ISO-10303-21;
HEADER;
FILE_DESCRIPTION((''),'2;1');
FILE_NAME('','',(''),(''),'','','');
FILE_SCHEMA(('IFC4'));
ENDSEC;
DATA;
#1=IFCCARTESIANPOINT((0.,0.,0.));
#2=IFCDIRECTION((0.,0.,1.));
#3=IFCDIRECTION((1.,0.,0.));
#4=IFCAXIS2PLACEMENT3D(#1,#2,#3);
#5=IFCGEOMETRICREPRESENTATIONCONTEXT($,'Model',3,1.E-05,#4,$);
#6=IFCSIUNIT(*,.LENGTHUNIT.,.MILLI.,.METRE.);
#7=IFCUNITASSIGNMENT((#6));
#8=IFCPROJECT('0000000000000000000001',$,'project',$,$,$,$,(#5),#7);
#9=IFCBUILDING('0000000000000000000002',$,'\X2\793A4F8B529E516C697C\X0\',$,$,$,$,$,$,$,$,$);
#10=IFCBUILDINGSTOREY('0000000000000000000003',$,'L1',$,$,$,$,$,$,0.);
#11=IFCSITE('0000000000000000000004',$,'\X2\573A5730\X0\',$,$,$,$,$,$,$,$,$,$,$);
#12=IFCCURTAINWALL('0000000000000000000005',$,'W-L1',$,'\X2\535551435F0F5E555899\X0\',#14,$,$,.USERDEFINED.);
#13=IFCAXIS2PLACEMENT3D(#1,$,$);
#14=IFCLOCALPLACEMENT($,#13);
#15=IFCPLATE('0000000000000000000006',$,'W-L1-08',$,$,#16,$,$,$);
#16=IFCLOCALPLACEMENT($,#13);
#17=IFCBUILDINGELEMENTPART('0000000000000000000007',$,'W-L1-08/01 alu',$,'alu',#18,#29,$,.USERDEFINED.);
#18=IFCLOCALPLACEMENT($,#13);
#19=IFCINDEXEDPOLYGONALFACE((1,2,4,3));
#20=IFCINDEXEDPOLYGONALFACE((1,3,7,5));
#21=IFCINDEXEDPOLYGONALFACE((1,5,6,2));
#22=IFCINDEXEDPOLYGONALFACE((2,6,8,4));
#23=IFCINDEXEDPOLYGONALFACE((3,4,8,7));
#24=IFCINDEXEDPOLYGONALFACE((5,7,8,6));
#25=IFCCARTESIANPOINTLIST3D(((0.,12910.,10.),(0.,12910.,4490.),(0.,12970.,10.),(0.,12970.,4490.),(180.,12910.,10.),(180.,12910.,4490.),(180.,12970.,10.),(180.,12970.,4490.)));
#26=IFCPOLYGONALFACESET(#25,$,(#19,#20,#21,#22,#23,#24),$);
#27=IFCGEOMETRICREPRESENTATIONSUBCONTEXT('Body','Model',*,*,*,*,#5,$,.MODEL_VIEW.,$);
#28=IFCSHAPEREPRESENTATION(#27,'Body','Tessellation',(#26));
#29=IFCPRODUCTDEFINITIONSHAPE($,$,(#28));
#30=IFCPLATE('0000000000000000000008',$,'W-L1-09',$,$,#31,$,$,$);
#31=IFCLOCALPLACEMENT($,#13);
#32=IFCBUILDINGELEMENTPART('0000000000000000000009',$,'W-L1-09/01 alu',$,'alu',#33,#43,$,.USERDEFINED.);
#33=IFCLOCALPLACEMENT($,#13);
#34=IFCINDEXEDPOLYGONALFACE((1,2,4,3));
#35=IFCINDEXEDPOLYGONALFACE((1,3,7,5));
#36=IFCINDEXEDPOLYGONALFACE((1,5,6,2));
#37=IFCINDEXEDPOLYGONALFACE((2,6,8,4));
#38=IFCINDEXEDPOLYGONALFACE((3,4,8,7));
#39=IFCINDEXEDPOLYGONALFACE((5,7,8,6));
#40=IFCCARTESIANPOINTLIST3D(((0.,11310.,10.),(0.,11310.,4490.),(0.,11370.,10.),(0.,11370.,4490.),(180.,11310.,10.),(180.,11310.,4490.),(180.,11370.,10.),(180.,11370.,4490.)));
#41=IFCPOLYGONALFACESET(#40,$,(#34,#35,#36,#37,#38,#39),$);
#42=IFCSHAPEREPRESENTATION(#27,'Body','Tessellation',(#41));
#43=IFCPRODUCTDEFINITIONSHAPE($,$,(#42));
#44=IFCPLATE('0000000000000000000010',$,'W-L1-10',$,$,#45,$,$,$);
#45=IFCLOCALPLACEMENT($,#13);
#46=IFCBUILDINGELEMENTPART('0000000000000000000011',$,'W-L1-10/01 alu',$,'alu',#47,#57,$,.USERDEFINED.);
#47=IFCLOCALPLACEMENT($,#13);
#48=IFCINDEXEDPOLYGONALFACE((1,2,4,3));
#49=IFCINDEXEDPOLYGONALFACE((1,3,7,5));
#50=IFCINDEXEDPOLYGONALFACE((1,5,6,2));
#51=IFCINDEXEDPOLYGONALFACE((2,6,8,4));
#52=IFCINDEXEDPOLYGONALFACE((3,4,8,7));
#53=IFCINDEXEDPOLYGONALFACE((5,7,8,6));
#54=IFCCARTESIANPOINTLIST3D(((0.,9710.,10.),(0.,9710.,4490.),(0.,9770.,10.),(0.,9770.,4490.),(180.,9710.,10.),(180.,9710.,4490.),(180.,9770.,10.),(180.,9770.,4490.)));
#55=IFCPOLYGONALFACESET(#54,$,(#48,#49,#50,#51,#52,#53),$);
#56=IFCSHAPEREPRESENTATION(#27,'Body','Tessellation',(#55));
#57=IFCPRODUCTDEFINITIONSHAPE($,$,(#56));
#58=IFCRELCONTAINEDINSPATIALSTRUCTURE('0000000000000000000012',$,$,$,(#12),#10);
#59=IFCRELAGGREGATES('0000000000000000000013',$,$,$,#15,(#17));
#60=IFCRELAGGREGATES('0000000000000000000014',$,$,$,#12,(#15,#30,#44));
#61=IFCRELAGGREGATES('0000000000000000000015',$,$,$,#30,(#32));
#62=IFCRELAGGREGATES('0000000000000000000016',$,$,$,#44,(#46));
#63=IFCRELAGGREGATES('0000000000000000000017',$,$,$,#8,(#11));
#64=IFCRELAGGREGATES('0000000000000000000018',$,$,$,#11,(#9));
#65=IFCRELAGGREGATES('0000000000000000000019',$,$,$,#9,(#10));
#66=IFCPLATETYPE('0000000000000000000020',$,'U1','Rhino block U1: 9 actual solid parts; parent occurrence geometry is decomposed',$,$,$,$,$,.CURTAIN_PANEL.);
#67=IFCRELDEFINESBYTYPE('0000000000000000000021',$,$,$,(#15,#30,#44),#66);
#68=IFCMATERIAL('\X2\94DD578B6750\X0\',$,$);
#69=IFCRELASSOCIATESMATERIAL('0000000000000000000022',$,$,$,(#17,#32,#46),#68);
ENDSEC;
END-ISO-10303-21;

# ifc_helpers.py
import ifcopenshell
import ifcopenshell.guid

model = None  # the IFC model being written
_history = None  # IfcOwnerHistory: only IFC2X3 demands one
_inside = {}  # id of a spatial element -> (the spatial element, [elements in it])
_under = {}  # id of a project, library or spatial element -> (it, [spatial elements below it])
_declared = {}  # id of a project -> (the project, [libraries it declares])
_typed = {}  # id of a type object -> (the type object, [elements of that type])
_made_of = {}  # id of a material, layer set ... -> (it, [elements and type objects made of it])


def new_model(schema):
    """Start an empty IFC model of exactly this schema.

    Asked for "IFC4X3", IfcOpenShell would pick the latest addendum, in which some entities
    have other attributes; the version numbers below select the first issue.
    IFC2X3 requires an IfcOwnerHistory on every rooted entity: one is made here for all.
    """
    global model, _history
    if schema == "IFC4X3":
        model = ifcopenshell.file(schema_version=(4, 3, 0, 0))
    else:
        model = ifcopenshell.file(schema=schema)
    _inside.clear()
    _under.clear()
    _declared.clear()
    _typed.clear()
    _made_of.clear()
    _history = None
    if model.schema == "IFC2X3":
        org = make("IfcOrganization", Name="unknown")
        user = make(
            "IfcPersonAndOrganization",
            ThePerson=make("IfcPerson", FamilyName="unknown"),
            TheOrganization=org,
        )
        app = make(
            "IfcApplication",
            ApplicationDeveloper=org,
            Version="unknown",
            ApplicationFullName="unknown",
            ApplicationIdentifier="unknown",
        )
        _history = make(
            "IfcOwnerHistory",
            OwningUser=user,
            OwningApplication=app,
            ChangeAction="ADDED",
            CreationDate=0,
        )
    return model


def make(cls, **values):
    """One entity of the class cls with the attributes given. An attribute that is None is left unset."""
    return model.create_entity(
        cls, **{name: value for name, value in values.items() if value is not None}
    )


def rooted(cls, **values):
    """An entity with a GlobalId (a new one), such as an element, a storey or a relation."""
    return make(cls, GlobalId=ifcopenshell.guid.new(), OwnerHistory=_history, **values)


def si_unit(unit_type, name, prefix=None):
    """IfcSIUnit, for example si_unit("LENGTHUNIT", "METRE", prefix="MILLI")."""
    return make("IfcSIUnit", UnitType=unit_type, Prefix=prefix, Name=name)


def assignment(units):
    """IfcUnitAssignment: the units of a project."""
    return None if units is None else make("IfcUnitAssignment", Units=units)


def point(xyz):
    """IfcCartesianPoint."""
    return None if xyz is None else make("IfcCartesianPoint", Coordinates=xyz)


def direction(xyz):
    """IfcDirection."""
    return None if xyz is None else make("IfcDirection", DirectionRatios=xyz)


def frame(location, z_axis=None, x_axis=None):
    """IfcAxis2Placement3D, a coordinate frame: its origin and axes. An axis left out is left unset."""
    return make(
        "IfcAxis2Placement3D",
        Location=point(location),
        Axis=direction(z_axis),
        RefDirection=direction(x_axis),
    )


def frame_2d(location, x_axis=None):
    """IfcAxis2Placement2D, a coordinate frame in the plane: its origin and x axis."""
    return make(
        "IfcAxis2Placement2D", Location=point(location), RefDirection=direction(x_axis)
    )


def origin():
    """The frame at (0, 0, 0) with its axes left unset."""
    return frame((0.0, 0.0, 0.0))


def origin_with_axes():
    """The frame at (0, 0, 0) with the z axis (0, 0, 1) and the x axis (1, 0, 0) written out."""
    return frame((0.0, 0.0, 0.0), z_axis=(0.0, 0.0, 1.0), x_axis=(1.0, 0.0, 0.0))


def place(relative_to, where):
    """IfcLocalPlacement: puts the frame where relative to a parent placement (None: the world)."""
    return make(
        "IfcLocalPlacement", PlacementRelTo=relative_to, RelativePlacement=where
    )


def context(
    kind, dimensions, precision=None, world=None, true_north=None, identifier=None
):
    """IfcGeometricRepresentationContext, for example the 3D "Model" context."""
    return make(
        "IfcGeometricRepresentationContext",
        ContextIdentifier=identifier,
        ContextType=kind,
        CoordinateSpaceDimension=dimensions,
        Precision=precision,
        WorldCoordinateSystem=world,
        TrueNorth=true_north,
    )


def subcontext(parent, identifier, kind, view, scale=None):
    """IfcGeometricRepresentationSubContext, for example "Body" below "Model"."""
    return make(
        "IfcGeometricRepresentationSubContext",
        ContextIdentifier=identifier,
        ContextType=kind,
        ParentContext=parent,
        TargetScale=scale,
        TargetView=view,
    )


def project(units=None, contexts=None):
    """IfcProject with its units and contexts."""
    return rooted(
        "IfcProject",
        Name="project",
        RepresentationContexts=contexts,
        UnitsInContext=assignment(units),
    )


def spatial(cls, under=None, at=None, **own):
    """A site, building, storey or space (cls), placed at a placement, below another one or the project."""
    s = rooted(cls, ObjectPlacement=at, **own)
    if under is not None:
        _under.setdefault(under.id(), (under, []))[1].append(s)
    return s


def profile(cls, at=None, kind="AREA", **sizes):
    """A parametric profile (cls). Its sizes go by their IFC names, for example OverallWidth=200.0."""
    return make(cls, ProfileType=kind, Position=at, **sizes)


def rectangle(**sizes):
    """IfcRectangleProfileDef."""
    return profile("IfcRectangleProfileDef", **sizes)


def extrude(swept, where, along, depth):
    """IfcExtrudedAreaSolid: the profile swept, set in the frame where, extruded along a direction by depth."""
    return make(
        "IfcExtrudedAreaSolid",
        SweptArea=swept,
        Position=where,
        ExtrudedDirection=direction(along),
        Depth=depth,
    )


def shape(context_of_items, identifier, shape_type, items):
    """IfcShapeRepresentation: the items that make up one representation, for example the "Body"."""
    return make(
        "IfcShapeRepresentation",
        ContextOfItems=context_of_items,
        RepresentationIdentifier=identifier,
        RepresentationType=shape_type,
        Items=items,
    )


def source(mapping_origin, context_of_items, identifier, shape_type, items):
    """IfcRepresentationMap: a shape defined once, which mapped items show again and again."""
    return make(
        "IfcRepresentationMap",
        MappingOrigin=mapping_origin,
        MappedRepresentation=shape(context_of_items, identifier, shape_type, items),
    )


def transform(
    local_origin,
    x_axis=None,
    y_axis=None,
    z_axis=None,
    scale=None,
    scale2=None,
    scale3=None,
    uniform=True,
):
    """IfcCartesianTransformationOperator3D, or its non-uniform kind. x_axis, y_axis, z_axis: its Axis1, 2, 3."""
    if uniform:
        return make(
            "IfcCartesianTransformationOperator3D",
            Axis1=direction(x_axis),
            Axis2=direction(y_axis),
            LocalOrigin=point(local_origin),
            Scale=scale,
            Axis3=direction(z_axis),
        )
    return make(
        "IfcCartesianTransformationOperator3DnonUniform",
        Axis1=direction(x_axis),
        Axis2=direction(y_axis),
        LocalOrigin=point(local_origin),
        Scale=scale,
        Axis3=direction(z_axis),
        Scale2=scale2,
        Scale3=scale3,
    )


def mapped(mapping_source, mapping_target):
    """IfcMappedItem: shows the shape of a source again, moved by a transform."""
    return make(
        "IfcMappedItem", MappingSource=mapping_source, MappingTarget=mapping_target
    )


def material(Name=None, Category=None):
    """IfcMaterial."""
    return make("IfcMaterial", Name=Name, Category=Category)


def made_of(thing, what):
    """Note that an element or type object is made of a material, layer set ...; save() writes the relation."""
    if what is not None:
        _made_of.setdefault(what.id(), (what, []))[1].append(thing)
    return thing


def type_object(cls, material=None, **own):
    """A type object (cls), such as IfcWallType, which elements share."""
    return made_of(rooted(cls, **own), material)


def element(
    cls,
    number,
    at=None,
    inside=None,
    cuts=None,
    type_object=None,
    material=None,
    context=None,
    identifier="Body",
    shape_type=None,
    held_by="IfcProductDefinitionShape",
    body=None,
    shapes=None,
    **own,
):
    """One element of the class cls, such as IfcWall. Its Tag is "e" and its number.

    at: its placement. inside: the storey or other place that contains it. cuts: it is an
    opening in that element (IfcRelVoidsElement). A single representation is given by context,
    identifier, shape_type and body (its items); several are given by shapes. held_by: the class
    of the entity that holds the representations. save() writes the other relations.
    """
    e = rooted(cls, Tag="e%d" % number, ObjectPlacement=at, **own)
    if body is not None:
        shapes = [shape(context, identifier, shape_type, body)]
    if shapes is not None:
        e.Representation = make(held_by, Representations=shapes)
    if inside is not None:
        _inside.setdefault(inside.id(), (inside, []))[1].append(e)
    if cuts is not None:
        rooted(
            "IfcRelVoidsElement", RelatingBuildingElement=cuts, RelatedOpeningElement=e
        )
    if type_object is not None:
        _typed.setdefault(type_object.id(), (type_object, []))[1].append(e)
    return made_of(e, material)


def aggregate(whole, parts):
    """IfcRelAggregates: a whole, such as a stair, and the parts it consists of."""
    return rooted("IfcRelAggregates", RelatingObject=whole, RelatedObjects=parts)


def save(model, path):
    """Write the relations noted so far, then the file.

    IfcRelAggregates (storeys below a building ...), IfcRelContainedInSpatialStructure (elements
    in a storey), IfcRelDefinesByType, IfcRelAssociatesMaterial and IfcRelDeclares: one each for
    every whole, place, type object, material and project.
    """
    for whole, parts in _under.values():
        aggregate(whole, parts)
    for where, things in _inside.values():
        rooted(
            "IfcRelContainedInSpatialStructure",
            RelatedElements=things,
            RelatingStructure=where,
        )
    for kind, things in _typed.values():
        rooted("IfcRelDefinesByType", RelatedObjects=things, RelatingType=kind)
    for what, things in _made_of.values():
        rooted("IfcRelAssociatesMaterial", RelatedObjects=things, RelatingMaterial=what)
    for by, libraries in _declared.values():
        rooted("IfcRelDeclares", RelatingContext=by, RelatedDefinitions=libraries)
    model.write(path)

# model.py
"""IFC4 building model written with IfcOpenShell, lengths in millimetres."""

from ifc_helpers import new_model, si_unit, frame, frame_2d, origin, origin_with_axes, place, context, subcontext, project, spatial, rectangle, extrude, source, transform, mapped, material, type_object, element, aggregate, save


model = new_model("IFC4")

# Units and contexts
model_context = context("Model", 3, precision=1e-05, world=origin_with_axes())
body_context = subcontext(model_context, "Body", "Model", "MODEL_VIEW")
ifc_project = project(units=[si_unit("LENGTHUNIT", "METRE", prefix="MILLI")], contexts=[model_context])

# Site, building, storey
site = spatial("IfcSite", under=ifc_project, Name="场地")
building = spatial("IfcBuilding", under=site, Name="示例办公楼")
storey = spatial("IfcBuildingStorey", under=building, Name="L1", Elevation=0.0)

# Curtain wall, plates, building element parts
curtain_wall = element("IfcCurtainWall", 1, inside=storey, Name="W-L1", ObjectType="单元式幕墙", PredefinedType="USERDEFINED")
plate_type = type_object("IfcPlateType", Name="U1", Description="Rhino block U1: 9 actual solid parts; parent occurrence geometry is decomposed", PredefinedType="CURTAIN_PANEL")
plate_1_placement = place(None, frame((0.0, 12970.0, 10.0), z_axis=(0.0, 0.0, 1.0), x_axis=(0.0, -1.0, 0.0)))
plate_1 = element("IfcPlate", 2, at=plate_1_placement, type_object=plate_type, Name="W-L1-08")
ifc_material_1 = material(Name="铝型材")
shared_shape_1 = source(origin(), body_context, "Body", "SweptSolid", [
    extrude(rectangle(XDim=60.0, YDim=180.0, at=frame_2d((30.0, 90.0))), origin(), (0.0, 0.0, 1.0), 4480.0),
])
building_element_part_1_placement = place(plate_1_placement, origin())
building_element_part_1 = element("IfcBuildingElementPart", 3, at=building_element_part_1_placement, material=ifc_material_1, Name="W-L1-08/01 alu", ObjectType="alu", PredefinedType="USERDEFINED", context=body_context, shape_type="MappedRepresentation", body=[
    mapped(shared_shape_1, transform((0.0, 0.0, 0.0))),
])
plate_2_placement = place(None, frame((0.0, 11370.0, 10.0), z_axis=(0.0, 0.0, 1.0), x_axis=(0.0, -1.0, 0.0)))
plate_2 = element("IfcPlate", 4, at=plate_2_placement, type_object=plate_type, Name="W-L1-09")
building_element_part_2_placement = place(plate_2_placement, origin())
building_element_part_2 = element("IfcBuildingElementPart", 5, at=building_element_part_2_placement, material=ifc_material_1, Name="W-L1-09/01 alu", ObjectType="alu", PredefinedType="USERDEFINED", context=body_context, shape_type="MappedRepresentation", body=[
    mapped(shared_shape_1, transform((0.0, 0.0, 0.0))),
])
plate_3_placement = place(None, frame((0.0, 9770.0, 10.0), z_axis=(0.0, 0.0, 1.0), x_axis=(0.0, -1.0, 0.0)))
plate_3 = element("IfcPlate", 6, at=plate_3_placement, type_object=plate_type, Name="W-L1-10")
building_element_part_3_placement = place(plate_3_placement, origin())
building_element_part_3 = element("IfcBuildingElementPart", 7, at=building_element_part_3_placement, material=ifc_material_1, Name="W-L1-10/01 alu", ObjectType="alu", PredefinedType="USERDEFINED", context=body_context, shape_type="MappedRepresentation", body=[
    mapped(shared_shape_1, transform((0.0, 0.0, 0.0))),
])
aggregate(plate_1, [building_element_part_1])
aggregate(curtain_wall, [plate_1, plate_2, plate_3])
aggregate(plate_2, [building_element_part_2])
aggregate(plate_3, [building_element_part_3])

save(model, "model.ifc")
